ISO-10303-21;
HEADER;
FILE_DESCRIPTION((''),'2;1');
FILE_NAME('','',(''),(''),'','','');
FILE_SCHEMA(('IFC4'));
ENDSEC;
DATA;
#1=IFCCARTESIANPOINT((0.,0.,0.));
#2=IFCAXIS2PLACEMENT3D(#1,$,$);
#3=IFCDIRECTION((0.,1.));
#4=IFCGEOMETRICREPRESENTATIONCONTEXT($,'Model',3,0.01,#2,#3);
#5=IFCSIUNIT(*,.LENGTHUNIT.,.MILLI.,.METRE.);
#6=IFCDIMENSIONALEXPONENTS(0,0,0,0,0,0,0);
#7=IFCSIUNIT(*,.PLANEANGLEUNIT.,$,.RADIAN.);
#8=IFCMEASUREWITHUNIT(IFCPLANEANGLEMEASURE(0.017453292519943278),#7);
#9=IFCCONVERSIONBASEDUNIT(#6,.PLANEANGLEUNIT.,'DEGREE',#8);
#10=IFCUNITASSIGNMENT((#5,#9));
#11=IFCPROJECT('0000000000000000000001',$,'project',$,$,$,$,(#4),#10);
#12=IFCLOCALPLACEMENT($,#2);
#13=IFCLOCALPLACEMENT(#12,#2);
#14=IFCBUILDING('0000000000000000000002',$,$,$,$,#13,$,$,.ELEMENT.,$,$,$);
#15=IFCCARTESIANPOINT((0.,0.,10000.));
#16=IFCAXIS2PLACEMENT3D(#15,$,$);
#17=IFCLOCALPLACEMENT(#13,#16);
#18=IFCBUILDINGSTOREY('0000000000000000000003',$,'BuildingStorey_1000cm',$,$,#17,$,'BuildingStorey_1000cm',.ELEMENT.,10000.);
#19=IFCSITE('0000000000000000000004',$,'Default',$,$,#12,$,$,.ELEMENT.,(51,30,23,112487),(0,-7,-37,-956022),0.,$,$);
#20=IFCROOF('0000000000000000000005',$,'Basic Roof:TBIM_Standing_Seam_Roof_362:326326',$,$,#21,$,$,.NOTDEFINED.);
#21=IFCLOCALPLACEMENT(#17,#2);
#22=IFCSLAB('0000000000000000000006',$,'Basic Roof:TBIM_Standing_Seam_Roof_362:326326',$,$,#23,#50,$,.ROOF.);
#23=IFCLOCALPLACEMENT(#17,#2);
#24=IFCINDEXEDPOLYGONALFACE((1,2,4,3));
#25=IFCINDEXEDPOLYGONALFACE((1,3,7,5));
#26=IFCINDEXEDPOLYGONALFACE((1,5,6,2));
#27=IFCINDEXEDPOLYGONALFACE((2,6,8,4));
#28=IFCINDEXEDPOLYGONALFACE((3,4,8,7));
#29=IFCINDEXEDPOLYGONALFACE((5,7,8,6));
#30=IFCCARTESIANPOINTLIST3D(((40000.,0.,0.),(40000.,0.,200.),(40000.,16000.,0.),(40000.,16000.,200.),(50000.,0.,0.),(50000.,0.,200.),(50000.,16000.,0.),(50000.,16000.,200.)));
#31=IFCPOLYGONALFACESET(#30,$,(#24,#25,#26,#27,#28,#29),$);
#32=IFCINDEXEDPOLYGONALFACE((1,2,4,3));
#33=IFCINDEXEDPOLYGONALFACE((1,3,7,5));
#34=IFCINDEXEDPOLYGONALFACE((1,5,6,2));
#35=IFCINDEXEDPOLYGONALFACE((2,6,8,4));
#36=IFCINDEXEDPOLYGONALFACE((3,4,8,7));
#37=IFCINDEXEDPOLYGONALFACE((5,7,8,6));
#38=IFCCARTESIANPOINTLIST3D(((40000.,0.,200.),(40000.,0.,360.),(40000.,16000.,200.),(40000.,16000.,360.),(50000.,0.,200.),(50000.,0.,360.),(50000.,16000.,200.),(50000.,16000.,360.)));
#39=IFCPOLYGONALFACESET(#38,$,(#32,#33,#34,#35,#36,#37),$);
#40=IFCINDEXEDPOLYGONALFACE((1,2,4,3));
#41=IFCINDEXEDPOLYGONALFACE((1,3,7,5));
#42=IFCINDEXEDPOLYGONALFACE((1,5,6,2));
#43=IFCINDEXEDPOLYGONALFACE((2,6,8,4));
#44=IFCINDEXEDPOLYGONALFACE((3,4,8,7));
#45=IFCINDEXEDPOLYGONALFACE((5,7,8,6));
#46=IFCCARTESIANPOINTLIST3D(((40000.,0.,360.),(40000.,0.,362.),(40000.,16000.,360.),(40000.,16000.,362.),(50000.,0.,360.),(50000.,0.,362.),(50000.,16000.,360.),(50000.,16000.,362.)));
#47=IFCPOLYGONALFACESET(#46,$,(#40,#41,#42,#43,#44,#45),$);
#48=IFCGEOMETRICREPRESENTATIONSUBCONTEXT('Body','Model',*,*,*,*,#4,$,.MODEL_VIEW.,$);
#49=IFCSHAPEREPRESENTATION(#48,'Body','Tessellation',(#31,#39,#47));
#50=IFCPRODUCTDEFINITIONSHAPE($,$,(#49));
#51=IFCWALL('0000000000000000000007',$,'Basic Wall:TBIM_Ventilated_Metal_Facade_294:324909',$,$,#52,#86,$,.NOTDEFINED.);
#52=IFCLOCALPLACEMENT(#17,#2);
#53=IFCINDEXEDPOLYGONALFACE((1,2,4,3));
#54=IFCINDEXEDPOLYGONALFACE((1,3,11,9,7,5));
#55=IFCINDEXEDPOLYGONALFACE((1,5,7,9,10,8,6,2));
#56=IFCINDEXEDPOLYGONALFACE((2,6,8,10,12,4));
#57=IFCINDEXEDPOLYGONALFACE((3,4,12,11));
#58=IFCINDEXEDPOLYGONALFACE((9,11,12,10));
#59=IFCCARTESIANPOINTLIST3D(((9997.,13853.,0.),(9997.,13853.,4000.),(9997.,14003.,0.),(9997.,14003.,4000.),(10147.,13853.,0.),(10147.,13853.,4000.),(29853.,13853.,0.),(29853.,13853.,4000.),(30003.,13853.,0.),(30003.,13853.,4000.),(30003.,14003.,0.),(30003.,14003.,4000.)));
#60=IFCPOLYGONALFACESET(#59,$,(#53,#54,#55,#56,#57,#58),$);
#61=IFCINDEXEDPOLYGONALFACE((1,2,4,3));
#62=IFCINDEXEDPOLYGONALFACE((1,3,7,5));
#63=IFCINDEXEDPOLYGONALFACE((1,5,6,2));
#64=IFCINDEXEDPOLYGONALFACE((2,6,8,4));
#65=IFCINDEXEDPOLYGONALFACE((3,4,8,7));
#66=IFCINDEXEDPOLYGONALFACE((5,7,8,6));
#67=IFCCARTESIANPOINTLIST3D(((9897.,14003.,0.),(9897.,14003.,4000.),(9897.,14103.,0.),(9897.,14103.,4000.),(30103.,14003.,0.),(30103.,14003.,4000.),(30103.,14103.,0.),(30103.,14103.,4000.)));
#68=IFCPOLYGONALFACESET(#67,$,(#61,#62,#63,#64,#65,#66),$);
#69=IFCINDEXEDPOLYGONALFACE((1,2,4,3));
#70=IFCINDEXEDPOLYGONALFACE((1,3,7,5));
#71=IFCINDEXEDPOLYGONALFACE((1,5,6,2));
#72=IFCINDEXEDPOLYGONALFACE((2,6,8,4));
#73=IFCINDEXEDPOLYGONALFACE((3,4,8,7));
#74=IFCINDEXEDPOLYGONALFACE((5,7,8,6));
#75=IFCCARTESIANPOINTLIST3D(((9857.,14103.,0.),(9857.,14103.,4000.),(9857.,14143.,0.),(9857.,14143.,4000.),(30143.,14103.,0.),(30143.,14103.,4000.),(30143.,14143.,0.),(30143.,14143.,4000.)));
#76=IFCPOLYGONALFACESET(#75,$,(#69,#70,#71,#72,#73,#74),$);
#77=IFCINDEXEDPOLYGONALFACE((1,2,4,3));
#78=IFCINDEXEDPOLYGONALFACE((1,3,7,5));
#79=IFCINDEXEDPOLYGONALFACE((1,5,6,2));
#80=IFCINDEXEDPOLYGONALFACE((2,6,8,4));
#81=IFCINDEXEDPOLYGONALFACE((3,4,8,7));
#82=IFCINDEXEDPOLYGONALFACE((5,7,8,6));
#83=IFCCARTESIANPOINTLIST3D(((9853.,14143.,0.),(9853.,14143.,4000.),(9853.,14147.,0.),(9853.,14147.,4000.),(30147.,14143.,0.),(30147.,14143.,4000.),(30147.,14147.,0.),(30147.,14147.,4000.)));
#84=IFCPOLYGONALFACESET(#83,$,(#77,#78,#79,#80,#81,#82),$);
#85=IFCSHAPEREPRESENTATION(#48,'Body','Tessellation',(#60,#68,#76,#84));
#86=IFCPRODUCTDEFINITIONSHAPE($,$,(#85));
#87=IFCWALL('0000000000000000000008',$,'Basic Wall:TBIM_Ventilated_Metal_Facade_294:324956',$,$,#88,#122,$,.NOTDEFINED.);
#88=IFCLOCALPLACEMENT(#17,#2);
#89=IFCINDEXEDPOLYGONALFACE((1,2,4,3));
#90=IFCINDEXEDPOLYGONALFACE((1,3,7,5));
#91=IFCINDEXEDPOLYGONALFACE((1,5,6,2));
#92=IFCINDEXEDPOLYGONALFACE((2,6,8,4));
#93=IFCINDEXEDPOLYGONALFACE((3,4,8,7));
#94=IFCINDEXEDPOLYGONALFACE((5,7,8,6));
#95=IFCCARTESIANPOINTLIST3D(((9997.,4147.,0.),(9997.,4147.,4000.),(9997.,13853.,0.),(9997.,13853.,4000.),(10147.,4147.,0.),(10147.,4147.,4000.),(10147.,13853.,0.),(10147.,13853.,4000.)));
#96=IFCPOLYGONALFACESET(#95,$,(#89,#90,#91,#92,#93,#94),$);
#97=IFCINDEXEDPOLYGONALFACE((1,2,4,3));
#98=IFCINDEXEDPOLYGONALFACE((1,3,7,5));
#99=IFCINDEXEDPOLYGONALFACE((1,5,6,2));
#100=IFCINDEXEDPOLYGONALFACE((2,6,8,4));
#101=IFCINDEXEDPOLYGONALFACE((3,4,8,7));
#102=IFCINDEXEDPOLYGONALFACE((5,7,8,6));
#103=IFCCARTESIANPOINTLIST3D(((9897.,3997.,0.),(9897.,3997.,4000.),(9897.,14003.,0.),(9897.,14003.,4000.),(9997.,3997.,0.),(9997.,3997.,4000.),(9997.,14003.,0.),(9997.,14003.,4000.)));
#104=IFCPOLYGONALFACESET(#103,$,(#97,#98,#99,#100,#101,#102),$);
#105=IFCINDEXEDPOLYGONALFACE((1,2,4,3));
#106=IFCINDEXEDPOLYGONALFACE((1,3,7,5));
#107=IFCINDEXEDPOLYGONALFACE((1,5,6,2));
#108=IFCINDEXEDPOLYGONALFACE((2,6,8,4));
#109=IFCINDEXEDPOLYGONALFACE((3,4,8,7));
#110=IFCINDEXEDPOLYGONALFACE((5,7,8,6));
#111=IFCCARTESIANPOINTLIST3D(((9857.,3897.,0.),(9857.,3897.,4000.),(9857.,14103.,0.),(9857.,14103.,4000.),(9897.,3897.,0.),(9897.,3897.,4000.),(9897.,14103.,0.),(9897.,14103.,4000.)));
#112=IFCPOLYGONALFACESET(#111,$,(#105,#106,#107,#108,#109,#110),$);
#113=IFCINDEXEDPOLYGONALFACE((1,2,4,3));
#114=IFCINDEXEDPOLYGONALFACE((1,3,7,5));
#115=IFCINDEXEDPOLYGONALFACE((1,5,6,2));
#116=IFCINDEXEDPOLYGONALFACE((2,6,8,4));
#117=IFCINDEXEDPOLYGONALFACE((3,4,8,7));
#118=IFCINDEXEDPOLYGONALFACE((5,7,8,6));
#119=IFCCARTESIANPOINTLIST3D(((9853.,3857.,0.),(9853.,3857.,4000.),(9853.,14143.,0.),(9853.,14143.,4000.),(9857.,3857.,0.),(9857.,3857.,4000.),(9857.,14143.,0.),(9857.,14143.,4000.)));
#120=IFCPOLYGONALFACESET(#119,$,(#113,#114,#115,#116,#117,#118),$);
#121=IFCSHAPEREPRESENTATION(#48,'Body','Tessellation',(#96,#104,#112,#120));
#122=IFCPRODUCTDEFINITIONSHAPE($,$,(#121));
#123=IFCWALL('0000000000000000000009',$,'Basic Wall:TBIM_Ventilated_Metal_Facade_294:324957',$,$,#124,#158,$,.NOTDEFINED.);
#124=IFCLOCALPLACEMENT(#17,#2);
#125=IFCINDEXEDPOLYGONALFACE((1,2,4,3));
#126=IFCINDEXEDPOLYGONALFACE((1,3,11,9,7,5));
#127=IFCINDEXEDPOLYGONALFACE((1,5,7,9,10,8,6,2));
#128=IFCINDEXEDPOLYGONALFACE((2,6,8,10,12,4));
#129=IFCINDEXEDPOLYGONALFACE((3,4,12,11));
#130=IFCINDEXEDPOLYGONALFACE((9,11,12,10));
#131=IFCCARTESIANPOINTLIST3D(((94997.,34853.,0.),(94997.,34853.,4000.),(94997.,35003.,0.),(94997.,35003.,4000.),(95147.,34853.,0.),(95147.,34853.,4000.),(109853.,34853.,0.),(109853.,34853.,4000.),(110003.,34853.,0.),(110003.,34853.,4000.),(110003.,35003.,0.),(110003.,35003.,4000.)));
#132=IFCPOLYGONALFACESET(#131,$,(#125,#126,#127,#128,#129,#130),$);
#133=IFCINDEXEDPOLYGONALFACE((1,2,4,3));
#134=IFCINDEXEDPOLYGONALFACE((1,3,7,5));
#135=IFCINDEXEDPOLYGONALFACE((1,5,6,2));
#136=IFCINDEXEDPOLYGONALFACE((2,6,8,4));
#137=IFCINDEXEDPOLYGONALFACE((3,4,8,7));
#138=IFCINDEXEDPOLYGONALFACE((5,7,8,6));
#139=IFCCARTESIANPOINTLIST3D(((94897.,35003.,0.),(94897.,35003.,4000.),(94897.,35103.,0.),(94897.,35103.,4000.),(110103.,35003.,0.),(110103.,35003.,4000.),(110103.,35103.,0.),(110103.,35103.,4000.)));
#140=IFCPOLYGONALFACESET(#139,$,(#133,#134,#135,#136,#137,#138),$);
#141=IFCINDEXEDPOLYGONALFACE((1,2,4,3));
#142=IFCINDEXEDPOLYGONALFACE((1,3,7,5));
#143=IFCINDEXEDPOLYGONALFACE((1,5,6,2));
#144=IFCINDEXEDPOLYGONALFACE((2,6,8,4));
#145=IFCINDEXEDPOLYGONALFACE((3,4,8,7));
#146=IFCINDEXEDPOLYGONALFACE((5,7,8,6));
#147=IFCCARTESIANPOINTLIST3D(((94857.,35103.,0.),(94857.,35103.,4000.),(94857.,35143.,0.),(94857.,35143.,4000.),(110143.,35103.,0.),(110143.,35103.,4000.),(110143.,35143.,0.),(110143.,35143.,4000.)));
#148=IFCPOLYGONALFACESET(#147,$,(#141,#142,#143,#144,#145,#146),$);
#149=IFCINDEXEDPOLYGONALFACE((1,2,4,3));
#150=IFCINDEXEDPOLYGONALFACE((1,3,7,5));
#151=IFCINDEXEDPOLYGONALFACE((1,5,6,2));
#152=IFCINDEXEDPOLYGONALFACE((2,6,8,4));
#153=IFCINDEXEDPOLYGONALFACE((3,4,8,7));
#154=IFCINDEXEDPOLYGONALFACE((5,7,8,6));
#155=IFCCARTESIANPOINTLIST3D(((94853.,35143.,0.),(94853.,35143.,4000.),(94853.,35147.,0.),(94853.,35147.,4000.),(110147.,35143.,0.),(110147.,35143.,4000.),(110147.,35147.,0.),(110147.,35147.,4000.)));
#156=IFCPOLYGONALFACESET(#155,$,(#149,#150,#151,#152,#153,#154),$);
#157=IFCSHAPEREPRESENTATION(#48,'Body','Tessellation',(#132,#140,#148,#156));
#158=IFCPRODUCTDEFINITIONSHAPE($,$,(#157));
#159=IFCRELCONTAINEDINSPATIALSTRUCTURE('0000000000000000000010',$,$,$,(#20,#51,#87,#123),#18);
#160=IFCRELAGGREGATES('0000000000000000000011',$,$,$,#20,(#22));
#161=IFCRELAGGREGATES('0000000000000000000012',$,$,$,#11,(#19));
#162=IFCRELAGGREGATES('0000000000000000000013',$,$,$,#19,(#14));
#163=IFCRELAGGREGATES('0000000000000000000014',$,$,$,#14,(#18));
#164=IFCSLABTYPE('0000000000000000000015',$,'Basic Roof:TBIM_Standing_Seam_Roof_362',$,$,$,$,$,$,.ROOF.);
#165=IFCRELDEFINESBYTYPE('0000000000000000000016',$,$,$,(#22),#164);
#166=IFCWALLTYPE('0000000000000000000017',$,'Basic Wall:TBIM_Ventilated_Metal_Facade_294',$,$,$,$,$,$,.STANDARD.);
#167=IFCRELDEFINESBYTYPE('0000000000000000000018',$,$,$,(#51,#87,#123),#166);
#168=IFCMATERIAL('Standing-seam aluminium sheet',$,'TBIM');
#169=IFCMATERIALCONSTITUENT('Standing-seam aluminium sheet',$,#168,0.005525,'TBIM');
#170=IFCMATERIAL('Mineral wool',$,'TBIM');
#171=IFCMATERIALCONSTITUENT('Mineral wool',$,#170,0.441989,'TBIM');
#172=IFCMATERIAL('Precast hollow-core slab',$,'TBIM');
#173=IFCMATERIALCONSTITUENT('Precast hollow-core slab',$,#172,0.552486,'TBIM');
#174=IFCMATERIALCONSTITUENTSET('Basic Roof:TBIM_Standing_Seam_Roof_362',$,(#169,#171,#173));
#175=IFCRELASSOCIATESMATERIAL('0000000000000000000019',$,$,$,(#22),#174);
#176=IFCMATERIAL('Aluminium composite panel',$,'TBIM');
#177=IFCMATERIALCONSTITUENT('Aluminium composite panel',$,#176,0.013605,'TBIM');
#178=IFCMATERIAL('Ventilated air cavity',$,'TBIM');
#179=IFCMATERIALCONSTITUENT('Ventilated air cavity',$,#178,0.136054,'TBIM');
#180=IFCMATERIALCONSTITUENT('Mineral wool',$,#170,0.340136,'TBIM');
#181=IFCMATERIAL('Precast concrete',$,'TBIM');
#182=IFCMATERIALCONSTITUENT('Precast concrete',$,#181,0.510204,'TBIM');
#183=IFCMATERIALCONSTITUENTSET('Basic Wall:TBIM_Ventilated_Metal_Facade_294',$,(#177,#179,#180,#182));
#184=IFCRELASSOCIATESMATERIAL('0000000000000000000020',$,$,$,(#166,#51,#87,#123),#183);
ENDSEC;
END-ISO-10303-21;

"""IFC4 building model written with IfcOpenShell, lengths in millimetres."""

from ifc_helpers import new_model, entity, si_unit, converted_unit, direction, frame, origin, place, context, subcontext, project, spatial, indexed_curve, outline, extrude, material, constituent, constituent_set, type_object, element, aggregate, save


model = new_model("IFC4")

# Units and contexts
model_context = context("Model", 3, precision=0.01, world=origin(), true_north=direction((0.0, 1.0)))
body_context = subcontext(model_context, "Body", "Model", "MODEL_VIEW")
ifc_project = project(units=[si_unit("LENGTHUNIT", "METRE", prefix="MILLI"), converted_unit("PLANEANGLEUNIT", "DEGREE", entity("IfcPlaneAngleMeasure", 0.017453292519943278), si_unit("PLANEANGLEUNIT", "RADIAN"), dimensions=[0, 0, 0, 0, 0, 0, 0])], contexts=[model_context])

# Site, building, storey
site_placement = place(None, origin())
site = spatial("IfcSite", under=ifc_project, at=site_placement, Name="Default", CompositionType="ELEMENT", RefLatitude=(51, 30, 23, 112487), RefLongitude=(0, -7, -37, -956022), RefElevation=0.0)
building_placement = place(site_placement, origin())
building = spatial("IfcBuilding", under=site, at=building_placement, CompositionType="ELEMENT")
storey_placement = place(building_placement, frame((0.0, 0.0, 10000.0)))
storey = spatial("IfcBuildingStorey", under=building, at=storey_placement, Name="BuildingStorey_1000cm", LongName="BuildingStorey_1000cm", CompositionType="ELEMENT", Elevation=10000.0)

# Shared definitions
ifc_material_1 = material(Name="Precast hollow-core slab", Category="TBIM")

# Roof, slab
ifc_material_2 = material(Name="Standing-seam aluminium sheet", Category="TBIM")
ifc_constituent_1 = constituent(ifc_material_2, Name="Standing-seam aluminium sheet", Category="TBIM", fraction=0.005525)
ifc_material_3 = material(Name="Mineral wool", Category="TBIM")
ifc_constituent_2 = constituent(ifc_material_3, Name="Mineral wool", Category="TBIM", fraction=0.441989)
ifc_constituent_3 = constituent(ifc_material_1, Name="Precast hollow-core slab", Category="TBIM", fraction=0.552486)
ifc_constituent_set_1 = constituent_set(constituents=[ifc_constituent_1, ifc_constituent_2, ifc_constituent_3], Name="Basic Roof:TBIM_Standing_Seam_Roof_362")
slab_type_1 = type_object("IfcSlabType", Name="Basic Roof:TBIM_Standing_Seam_Roof_362", PredefinedType="ROOF")
roof_1_placement = place(storey_placement, frame((40000.0, 0.0, 0.0)))
roof_1 = element("IfcRoof", 1, at=roof_1_placement, inside=storey, Name="Basic Roof:TBIM_Standing_Seam_Roof_362:326326", PredefinedType="NOTDEFINED")
slab_1_placement = place(roof_1_placement, origin())
slab_1 = element("IfcSlab", 2, at=slab_1_placement, type_object=slab_type_1, material=ifc_constituent_set_1, Name="Basic Roof:TBIM_Standing_Seam_Roof_362:326326", PredefinedType="ROOF", context=body_context, shape_type="SweptSolid", body=[
    extrude(outline(indexed_curve([(-5000.0, 8000.0), (-5000.0, -8000.0), (5000.0, -8000.0), (5000.0, 8000.0), (-5000.0, 8000.0)], self_intersect=False)), frame((5000.0, 8000.0, 0.0)), (0.0, 0.0, 1.0), 200.0),
    extrude(outline(indexed_curve([(-5000.0, 8000.0), (-5000.0, -8000.0), (5000.0, -8000.0), (5000.0, 8000.0), (-5000.0, 8000.0)], self_intersect=False)), frame((5000.0, 8000.0, 200.0)), (0.0, 0.0, 1.0), 160.0),
    extrude(outline(indexed_curve([(-5000.0, 8000.0), (-5000.0, -8000.0), (5000.0, -8000.0), (5000.0, 8000.0), (-5000.0, 8000.0)], self_intersect=False)), frame((5000.0, 8000.0, 360.0)), (0.0, 0.0, 1.0), 2.0),
])
aggregate(roof_1, [slab_1])

# Walls
ifc_material_4 = material(Name="Aluminium composite panel", Category="TBIM")
ifc_constituent_4 = constituent(ifc_material_4, Name="Aluminium composite panel", Category="TBIM", fraction=0.013605)
ifc_material_5 = material(Name="Ventilated air cavity", Category="TBIM")
ifc_constituent_5 = constituent(ifc_material_5, Name="Ventilated air cavity", Category="TBIM", fraction=0.136054)
ifc_constituent_6 = constituent(ifc_material_3, Name="Mineral wool", Category="TBIM", fraction=0.340136)
ifc_material_6 = material(Name="Precast concrete", Category="TBIM")
ifc_constituent_7 = constituent(ifc_material_6, Name="Precast concrete", Category="TBIM", fraction=0.510204)
ifc_constituent_set_2 = constituent_set(constituents=[ifc_constituent_4, ifc_constituent_5, ifc_constituent_6, ifc_constituent_7], Name="Basic Wall:TBIM_Ventilated_Metal_Facade_294")
wall_type = type_object("IfcWallType", Name="Basic Wall:TBIM_Ventilated_Metal_Facade_294", PredefinedType="STANDARD", material=ifc_constituent_set_2)
wall_1_placement = place(storey_placement, frame((9853.0, 14000.0, 0.0)))
element("IfcWall", 3, at=wall_1_placement, inside=storey, type_object=wall_type, material=ifc_constituent_set_2, Name="Basic Wall:TBIM_Ventilated_Metal_Facade_294:324909", PredefinedType="NOTDEFINED", context=body_context, shape_type="SweptSolid", body=[
    extrude(outline(indexed_curve([(-9853.0, -50.0), (9853.0, -50.0), (10003.0, -50.0), (10003.0, 100.0), (-10003.0, 100.0), (-10003.0, -50.0), (-9853.0, -50.0)], self_intersect=False)), frame((10147.0, -97.0, 0.0)), (0.0, 0.0, 1.0), 4000.0),
    extrude(outline(indexed_curve([(-10103.0, -50.0), (10103.0, -50.0), (10103.0, 50.0), (-10103.0, 50.0), (-10103.0, -50.0)], self_intersect=False)), frame((10147.0, 53.0, 0.0)), (0.0, 0.0, 1.0), 4000.0),
    extrude(outline(indexed_curve([(-10143.0, -20.0), (10143.0, -20.0), (10143.0, 20.0), (-10143.0, 20.0), (-10143.0, -20.0)], self_intersect=False)), frame((10147.0, 123.0, 0.0)), (0.0, 0.0, 1.0), 4000.0),
    extrude(outline(indexed_curve([(-2.0, -10147.0), (2.0, -10147.0), (2.0, 10147.0), (-2.0, 10147.0), (-2.0, -10147.0)], self_intersect=False)), frame((10147.0, 145.0, 0.0), z_axis=(0.0, 0.0, 1.0), x_axis=(0.0, -1.0, 0.0)), (0.0, 0.0, 1.0), 4000.0),
])
wall_2_placement = place(storey_placement, frame((10000.0, 4147.0, 0.0), z_axis=(0.0, 0.0, 1.0), x_axis=(0.0, 1.0, 0.0)))
element("IfcWall", 4, at=wall_2_placement, inside=storey, type_object=wall_type, material=ifc_constituent_set_2, Name="Basic Wall:TBIM_Ventilated_Metal_Facade_294:324956", PredefinedType="NOTDEFINED", context=body_context, shape_type="SweptSolid", body=[
    extrude(outline(indexed_curve([(-75.0, -4853.0), (75.0, -4853.0), (75.0, 4853.0), (-75.0, 4853.0), (-75.0, -4853.0)], self_intersect=False)), frame((4853.0, -72.0, 0.0), z_axis=(0.0, 0.0, 1.0), x_axis=(0.0, 1.0, 0.0)), (0.0, 0.0, 1.0), 4000.0),
    extrude(outline(indexed_curve([(-5003.0, -50.0), (5003.0, -50.0), (5003.0, 50.0), (-5003.0, 50.0), (-5003.0, -50.0)], self_intersect=False)), frame((4853.0, 53.0, 0.0)), (0.0, 0.0, 1.0), 4000.0),
    extrude(outline(indexed_curve([(-5103.0, -20.0), (5103.0, -20.0), (5103.0, 20.0), (-5103.0, 20.0), (-5103.0, -20.0)], self_intersect=False)), frame((4853.0, 123.0, 0.0)), (0.0, 0.0, 1.0), 4000.0),
    extrude(outline(indexed_curve([(-2.0, -5143.0), (2.0, -5143.0), (2.0, 5143.0), (-2.0, 5143.0), (-2.0, -5143.0)], self_intersect=False)), frame((4853.0, 145.0, 0.0), z_axis=(0.0, 0.0, 1.0), x_axis=(0.0, -1.0, 0.0)), (0.0, 0.0, 1.0), 4000.0),
])
wall_3_placement = place(storey_placement, frame((94853.0, 35000.0, 0.0)))
element("IfcWall", 5, at=wall_3_placement, inside=storey, type_object=wall_type, material=ifc_constituent_set_2, Name="Basic Wall:TBIM_Ventilated_Metal_Facade_294:324957", PredefinedType="NOTDEFINED", context=body_context, shape_type="SweptSolid", body=[
    extrude(outline(indexed_curve([(-7353.0, -50.0), (7353.0, -50.0), (7503.0, -50.0), (7503.0, 100.0), (-7503.0, 100.0), (-7503.0, -50.0), (-7353.0, -50.0)], self_intersect=False)), frame((7647.0, -97.0, 0.0)), (0.0, 0.0, 1.0), 4000.0),
    extrude(outline(indexed_curve([(-7603.0, -50.0), (7603.0, -50.0), (7603.0, 50.0), (-7603.0, 50.0), (-7603.0, -50.0)], self_intersect=False)), frame((7647.0, 53.0, 0.0)), (0.0, 0.0, 1.0), 4000.0),
    extrude(outline(indexed_curve([(-7643.0, -20.0), (7643.0, -20.0), (7643.0, 20.0), (-7643.0, 20.0), (-7643.0, -20.0)], self_intersect=False)), frame((7647.0, 123.0, 0.0)), (0.0, 0.0, 1.0), 4000.0),
    extrude(outline(indexed_curve([(-2.0, -7647.0), (2.0, -7647.0), (2.0, 7647.0), (-2.0, 7647.0), (-2.0, -7647.0)], self_intersect=False)), frame((7647.0, 145.0, 0.0), z_axis=(0.0, 0.0, 1.0), x_axis=(0.0, -1.0, 0.0)), (0.0, 0.0, 1.0), 4000.0),
])

save(model, "model.ifc")
